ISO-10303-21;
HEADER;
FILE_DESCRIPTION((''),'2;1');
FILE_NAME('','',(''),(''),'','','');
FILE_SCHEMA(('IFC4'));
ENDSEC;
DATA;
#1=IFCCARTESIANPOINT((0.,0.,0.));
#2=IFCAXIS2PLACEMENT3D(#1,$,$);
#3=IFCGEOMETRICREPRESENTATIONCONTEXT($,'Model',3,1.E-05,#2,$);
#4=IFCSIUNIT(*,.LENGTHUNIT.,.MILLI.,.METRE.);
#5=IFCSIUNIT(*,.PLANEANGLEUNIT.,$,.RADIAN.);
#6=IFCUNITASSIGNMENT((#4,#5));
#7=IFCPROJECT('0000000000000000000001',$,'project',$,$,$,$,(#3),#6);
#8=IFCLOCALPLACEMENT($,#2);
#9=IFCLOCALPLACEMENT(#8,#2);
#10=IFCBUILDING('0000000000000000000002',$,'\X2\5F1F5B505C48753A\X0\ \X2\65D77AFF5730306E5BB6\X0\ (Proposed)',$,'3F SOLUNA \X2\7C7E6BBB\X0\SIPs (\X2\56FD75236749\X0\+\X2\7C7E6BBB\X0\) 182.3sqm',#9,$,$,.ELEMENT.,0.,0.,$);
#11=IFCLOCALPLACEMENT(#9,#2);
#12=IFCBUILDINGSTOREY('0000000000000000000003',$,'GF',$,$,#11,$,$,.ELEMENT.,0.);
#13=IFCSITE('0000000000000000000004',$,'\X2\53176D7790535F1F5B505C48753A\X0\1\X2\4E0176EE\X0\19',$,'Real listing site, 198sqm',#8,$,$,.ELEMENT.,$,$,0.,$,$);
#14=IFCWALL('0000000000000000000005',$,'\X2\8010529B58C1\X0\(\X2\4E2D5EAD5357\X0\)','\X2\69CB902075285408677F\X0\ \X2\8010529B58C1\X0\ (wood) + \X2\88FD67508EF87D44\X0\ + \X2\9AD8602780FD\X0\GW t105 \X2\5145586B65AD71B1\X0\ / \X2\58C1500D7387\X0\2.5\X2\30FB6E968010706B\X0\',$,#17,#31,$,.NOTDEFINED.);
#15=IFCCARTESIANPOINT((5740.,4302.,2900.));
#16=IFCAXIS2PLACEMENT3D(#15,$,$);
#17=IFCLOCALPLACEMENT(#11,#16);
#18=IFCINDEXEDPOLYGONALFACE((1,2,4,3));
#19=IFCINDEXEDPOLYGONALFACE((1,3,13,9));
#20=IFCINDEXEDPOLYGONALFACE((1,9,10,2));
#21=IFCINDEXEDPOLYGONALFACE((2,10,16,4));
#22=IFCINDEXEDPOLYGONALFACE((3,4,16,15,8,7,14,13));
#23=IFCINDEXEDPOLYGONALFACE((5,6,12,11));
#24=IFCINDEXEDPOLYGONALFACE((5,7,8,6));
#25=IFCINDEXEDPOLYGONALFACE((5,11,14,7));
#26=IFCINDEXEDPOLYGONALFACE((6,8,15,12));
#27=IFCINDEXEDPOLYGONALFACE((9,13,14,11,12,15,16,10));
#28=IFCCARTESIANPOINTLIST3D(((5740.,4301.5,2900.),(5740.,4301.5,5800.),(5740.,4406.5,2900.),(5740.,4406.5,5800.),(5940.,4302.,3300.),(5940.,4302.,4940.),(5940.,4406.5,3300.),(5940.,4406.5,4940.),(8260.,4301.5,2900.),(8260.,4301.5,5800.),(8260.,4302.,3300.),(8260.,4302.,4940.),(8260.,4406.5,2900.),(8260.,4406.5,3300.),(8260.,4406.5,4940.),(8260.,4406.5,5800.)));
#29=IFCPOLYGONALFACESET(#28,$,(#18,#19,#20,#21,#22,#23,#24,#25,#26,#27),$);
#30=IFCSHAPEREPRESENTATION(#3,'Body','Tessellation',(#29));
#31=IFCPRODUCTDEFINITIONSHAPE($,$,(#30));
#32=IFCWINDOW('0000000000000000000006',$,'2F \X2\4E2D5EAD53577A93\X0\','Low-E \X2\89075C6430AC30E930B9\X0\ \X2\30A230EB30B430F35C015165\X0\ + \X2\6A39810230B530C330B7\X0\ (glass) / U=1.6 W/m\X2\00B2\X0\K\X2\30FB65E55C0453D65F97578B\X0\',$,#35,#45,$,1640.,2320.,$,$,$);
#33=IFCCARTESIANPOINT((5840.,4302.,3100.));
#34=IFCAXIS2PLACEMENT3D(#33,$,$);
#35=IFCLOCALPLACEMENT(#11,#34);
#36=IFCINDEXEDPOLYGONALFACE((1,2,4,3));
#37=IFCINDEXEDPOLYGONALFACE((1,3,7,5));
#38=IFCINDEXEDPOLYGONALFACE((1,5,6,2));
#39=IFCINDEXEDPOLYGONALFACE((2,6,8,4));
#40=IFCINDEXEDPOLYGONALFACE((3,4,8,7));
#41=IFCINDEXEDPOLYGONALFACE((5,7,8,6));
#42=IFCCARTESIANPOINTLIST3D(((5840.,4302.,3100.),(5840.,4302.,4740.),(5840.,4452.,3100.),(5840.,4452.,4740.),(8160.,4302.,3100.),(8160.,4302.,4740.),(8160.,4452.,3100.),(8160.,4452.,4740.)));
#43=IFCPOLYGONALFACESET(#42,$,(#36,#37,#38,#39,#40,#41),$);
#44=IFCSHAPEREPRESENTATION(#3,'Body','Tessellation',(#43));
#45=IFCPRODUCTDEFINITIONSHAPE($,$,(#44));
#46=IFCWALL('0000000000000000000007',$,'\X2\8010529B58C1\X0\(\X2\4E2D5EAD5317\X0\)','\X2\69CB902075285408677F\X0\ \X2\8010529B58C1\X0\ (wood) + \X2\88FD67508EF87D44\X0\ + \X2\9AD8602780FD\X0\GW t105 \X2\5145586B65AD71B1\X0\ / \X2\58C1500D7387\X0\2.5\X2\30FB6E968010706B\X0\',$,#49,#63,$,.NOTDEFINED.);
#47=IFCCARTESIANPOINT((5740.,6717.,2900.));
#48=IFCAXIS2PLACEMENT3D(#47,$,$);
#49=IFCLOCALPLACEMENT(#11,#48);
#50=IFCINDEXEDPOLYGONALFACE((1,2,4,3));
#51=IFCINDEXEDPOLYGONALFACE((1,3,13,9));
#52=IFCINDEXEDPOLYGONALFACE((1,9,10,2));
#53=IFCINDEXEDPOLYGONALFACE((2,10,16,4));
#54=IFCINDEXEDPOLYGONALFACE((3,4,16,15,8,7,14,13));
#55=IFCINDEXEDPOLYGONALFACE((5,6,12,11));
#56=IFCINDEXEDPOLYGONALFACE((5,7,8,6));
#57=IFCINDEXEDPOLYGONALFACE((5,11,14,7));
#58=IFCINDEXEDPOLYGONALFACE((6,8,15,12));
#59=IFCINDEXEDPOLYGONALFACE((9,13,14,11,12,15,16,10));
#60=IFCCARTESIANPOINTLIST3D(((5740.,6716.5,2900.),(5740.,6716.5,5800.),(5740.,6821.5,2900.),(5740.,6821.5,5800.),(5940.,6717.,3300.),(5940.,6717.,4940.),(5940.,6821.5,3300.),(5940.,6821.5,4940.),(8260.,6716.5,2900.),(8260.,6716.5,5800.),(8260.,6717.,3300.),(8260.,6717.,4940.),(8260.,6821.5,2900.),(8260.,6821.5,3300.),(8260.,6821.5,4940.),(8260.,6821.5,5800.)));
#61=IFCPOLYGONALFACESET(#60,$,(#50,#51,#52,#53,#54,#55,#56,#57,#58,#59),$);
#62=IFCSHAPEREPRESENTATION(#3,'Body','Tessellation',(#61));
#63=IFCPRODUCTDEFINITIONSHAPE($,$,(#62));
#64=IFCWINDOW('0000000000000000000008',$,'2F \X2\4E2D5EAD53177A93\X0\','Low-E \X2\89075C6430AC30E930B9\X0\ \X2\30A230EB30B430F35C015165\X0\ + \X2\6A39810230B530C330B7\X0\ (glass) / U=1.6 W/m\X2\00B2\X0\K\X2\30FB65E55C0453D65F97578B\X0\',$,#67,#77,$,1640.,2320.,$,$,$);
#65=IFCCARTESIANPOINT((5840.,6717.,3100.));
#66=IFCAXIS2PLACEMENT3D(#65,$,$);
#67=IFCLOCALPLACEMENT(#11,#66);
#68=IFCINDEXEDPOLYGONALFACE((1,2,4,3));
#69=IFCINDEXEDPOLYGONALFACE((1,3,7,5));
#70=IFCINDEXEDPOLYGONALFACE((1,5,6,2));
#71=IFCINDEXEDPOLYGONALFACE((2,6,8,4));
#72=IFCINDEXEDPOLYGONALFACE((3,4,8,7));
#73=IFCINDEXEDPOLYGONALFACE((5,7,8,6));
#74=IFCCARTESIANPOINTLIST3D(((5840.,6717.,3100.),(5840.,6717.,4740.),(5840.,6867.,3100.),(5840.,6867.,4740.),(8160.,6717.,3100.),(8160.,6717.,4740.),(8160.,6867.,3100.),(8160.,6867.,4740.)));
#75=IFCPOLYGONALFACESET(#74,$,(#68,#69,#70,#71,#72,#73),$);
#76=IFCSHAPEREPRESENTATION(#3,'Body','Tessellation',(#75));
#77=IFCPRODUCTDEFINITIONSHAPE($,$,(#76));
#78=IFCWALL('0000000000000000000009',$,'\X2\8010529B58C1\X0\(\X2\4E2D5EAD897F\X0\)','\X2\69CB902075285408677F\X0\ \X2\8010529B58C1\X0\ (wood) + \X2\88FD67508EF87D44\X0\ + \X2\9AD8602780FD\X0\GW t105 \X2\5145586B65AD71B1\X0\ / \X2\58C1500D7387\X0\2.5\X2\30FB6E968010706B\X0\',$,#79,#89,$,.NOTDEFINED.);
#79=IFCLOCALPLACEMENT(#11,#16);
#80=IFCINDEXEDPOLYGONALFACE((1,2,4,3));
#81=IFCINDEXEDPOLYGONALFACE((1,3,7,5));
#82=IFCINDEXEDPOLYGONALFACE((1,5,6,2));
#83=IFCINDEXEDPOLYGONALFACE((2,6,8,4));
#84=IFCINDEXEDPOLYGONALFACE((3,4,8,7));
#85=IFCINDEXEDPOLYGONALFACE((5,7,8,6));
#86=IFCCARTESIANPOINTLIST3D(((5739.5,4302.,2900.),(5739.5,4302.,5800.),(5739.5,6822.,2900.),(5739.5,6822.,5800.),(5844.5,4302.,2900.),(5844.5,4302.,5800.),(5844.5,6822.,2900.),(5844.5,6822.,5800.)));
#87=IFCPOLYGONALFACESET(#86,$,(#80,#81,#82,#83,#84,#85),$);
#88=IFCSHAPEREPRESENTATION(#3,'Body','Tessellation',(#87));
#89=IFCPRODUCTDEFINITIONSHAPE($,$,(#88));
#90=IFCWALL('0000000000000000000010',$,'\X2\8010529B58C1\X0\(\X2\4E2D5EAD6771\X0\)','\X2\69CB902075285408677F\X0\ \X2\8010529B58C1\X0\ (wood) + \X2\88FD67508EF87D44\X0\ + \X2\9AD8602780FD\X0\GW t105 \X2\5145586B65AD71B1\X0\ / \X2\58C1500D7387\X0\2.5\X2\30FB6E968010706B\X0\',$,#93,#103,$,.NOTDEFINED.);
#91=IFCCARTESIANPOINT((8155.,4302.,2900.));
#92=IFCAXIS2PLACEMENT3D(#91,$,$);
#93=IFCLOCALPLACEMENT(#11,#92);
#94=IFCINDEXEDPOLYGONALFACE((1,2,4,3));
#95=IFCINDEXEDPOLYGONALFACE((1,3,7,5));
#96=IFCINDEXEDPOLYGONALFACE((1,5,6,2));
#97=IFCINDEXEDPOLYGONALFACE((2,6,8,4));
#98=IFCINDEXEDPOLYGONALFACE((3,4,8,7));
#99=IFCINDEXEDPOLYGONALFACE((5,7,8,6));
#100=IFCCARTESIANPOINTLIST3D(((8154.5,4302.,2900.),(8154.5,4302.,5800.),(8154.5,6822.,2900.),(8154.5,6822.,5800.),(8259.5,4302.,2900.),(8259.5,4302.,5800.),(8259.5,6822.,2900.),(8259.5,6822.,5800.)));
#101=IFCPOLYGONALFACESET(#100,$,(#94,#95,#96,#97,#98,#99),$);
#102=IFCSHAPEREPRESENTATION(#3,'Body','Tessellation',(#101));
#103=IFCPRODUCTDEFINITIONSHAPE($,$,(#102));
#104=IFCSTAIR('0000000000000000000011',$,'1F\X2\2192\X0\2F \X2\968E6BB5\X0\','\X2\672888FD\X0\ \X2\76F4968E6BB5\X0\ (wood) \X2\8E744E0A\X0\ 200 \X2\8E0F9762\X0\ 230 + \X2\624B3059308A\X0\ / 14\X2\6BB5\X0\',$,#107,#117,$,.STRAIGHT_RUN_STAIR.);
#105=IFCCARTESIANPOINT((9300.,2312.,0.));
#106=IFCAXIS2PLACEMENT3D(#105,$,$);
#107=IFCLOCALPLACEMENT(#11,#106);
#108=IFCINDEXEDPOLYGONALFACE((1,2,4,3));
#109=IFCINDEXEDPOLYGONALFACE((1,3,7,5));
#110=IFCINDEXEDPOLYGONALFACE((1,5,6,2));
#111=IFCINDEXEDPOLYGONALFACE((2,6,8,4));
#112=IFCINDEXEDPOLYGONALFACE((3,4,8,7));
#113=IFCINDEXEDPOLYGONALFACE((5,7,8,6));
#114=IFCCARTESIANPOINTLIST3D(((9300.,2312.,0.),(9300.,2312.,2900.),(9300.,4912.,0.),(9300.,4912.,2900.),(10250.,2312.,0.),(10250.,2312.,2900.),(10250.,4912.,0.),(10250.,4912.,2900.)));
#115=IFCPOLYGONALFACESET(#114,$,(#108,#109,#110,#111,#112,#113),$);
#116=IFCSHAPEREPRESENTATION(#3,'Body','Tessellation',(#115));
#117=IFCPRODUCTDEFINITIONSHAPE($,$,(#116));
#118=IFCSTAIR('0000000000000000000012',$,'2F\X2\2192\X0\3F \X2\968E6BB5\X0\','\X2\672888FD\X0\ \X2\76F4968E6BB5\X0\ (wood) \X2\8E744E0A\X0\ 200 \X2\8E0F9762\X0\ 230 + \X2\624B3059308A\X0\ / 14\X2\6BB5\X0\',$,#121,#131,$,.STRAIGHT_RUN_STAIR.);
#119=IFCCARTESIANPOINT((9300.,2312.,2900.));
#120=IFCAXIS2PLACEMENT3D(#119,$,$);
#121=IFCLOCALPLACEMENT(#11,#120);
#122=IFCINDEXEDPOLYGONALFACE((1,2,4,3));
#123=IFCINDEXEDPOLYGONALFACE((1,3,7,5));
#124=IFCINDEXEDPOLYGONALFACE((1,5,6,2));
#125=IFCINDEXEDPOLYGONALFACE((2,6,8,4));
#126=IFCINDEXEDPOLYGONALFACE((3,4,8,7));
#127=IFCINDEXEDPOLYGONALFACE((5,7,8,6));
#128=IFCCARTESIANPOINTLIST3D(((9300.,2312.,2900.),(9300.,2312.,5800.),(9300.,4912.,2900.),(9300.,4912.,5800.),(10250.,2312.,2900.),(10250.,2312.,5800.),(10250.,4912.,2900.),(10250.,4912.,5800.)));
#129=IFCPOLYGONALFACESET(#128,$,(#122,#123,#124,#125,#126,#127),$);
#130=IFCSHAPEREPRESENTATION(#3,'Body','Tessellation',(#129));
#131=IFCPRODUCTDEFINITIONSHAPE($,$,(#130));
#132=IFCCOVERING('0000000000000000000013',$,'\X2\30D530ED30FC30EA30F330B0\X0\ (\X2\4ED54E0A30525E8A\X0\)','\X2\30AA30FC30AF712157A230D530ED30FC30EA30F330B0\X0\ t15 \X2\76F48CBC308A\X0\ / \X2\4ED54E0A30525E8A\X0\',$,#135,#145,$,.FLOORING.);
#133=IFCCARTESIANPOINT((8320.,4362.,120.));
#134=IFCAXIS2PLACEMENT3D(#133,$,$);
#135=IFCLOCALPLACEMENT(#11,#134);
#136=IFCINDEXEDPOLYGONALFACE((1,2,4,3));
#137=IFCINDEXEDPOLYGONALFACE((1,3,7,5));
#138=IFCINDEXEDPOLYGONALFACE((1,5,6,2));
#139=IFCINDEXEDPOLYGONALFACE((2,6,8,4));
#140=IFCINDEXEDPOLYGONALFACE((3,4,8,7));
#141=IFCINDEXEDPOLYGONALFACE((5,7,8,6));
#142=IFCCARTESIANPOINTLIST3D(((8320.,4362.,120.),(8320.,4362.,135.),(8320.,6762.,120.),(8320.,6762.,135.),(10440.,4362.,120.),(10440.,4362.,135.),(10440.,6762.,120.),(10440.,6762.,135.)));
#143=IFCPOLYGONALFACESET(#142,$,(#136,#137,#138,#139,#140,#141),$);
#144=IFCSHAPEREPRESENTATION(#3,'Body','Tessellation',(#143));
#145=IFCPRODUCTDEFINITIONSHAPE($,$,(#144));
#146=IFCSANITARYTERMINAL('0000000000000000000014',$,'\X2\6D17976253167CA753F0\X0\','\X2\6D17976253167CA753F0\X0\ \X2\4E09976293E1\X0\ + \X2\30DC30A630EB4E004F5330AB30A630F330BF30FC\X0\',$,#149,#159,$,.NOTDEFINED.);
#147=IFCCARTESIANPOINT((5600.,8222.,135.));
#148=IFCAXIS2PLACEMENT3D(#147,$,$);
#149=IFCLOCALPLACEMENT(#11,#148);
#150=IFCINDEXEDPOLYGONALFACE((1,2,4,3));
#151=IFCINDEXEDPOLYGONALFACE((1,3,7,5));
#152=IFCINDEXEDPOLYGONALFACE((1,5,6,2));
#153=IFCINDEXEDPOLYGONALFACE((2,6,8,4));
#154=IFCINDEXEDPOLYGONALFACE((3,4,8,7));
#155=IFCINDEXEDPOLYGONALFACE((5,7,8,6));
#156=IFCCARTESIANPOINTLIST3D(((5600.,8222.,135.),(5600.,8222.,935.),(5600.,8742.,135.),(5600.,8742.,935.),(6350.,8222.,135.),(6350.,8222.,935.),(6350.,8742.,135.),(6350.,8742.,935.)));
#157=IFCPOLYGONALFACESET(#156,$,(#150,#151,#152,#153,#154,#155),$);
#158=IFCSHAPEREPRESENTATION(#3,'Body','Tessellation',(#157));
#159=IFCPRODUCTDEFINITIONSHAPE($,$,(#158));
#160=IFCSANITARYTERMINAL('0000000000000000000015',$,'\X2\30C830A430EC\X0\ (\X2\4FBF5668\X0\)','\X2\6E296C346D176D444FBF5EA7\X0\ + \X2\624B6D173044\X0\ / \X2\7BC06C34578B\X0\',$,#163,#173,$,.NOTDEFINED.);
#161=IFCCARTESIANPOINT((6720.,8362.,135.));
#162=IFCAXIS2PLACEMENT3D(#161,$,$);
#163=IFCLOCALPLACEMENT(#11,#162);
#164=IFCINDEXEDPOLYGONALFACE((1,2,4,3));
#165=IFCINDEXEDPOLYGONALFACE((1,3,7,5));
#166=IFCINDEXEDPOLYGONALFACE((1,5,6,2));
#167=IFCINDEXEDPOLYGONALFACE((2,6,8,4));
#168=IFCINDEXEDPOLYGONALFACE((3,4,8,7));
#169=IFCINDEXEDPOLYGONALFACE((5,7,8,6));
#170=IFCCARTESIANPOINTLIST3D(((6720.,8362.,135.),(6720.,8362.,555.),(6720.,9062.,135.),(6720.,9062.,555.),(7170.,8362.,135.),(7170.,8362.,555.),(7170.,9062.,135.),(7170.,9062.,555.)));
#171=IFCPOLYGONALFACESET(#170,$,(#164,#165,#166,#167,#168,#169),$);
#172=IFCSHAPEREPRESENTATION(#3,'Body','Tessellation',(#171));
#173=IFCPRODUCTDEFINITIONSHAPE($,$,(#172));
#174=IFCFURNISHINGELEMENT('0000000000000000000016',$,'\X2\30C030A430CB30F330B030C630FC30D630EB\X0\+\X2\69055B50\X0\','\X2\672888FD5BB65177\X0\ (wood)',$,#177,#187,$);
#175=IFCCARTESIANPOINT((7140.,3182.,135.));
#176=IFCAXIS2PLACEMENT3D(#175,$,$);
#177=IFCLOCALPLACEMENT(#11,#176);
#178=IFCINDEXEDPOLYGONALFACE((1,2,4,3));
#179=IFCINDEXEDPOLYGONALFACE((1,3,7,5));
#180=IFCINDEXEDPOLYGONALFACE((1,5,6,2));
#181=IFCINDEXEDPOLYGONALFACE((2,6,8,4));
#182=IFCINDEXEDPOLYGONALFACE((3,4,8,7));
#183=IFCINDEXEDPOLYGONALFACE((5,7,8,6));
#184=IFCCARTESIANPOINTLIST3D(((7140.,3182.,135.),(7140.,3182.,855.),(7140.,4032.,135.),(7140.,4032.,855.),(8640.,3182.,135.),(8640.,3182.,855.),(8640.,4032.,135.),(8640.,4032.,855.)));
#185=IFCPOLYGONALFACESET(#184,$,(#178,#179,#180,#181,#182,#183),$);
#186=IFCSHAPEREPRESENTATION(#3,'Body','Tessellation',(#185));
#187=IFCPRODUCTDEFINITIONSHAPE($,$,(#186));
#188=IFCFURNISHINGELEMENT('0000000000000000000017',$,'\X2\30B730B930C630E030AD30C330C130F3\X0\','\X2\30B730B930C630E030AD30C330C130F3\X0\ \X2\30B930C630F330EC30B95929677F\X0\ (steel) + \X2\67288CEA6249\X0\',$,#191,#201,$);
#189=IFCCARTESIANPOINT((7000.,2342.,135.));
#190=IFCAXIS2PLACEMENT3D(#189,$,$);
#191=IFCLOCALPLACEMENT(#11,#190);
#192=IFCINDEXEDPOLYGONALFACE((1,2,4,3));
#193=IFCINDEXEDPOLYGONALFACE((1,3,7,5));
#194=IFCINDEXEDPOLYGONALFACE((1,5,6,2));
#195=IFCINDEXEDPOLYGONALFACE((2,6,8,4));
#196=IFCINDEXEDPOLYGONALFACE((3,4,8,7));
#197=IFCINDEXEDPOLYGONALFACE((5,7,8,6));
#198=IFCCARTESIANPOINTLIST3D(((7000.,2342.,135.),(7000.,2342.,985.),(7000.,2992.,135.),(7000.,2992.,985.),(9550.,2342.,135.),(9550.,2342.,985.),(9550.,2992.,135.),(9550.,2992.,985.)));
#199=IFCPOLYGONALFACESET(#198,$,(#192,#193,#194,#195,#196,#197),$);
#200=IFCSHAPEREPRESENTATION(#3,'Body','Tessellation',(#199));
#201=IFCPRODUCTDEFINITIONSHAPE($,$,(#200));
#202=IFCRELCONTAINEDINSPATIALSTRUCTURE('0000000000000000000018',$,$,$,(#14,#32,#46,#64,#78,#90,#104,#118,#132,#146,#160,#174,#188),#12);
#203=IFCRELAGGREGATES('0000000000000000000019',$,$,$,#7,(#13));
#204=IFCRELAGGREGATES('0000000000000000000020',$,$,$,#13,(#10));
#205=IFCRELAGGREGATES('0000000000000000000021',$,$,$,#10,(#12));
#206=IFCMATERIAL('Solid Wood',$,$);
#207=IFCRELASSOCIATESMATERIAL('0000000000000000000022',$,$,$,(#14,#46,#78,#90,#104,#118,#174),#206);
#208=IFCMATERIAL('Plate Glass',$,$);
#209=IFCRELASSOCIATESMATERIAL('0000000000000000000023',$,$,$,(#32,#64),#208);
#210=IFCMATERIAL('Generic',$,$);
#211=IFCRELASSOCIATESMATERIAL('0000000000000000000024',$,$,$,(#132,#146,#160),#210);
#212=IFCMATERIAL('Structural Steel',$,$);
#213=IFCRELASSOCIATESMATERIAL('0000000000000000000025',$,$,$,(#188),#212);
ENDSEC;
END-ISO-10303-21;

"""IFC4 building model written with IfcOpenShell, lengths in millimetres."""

from ifc_helpers import new_model, si_unit, frame, frame_2d, origin, place, context, project, spatial, rectangle, extrude, material, element, fill, save


model = new_model("IFC4")

# Units and contexts
model_context = context("Model", 3, precision=1e-05, world=origin())
ifc_project = project(units=[si_unit("LENGTHUNIT", "METRE", prefix="MILLI"), si_unit("PLANEANGLEUNIT", "RADIAN")], contexts=[model_context])

# Site, building, storey
site_placement = place(None, origin())
site = spatial("IfcSite", under=ifc_project, at=site_placement, Name="北海道弟子屈町1丁目19", ObjectType="Real listing site, 198sqm", CompositionType="ELEMENT", RefElevation=0.0)
building_placement = place(site_placement, origin())
building = spatial("IfcBuilding", under=site, at=building_placement, Name="弟子屈町 旗竿地の家 (Proposed)", ObjectType="3F SOLUNA 籾殻SIPs (国産杉+籾殻) 182.3sqm", CompositionType="ELEMENT", ElevationOfRefHeight=0.0, ElevationOfTerrain=0.0)
storey_placement = place(building_placement, origin())
storey = spatial("IfcBuildingStorey", under=building, at=storey_placement, Name="GF", CompositionType="ELEMENT", Elevation=0.0)

# Shared definitions
ifc_material_1 = material(Name="Solid Wood")

# Shared definitions
ifc_material_2 = material(Name="Plate Glass")

# Walls, openings, windows
wall_1_placement = place(storey_placement, frame((5740.0, 4302.0, 2900.0)))
wall_1 = element("IfcWall", 1, at=wall_1_placement, inside=storey, material=ifc_material_1, Name="耐力壁(中庭南)", Description="構造用合板 耐力壁 (wood) + 製材軸組 + 高性能GW t105 充填断熱 / 壁倍率2.5・準耐火", PredefinedType="NOTDEFINED", context=model_context, shape_type="SweptSolid", body=[
    extrude(rectangle(XDim=2520.0, YDim=105.0, at=frame_2d((1260.0, 52.0))), frame((5740.0, 4302.0, 2900.0)), (0.0, 0.0, 1.0), 2900.0),
])
opening_1_placement = place(storey_placement, frame((5840.0, 4302.0, 3100.0)))
opening_1 = element("IfcOpeningElement", 2, at=opening_1_placement, cuts=wall_1, PredefinedType="NOTDEFINED", context=model_context, shape_type="SweptSolid", body=[
    extrude(rectangle(XDim=2320.0, YDim=150.0, at=frame_2d((1160.0, 75.0))), frame((5840.0, 4302.0, 3100.0)), (0.0, 0.0, 1.0), 1640.0),
])
window_1_placement = place(storey_placement, frame((5840.0, 4302.0, 3100.0)))
window_1 = element("IfcWindow", 3, at=window_1_placement, inside=storey, material=ifc_material_2, Name="2F 中庭南窓", Description="Low-E 複層ガラス アルゴン封入 + 樹脂サッシ (glass) / U=1.6 W/m²K・日射取得型", OverallHeight=1640.0, OverallWidth=2320.0, context=model_context, shape_type="SweptSolid", body=[
    extrude(rectangle(XDim=2320.0, YDim=150.0, at=frame_2d((1160.0, 75.0))), frame((5840.0, 4302.0, 3100.0)), (0.0, 0.0, 1.0), 1640.0),
])
fill(opening_1, window_1)
wall_2_placement = place(storey_placement, frame((5740.0, 6717.0, 2900.0)))
wall_2 = element("IfcWall", 4, at=wall_2_placement, inside=storey, material=ifc_material_1, Name="耐力壁(中庭北)", Description="構造用合板 耐力壁 (wood) + 製材軸組 + 高性能GW t105 充填断熱 / 壁倍率2.5・準耐火", PredefinedType="NOTDEFINED", context=model_context, shape_type="SweptSolid", body=[
    extrude(rectangle(XDim=2520.0, YDim=105.0, at=frame_2d((1260.0, 52.0))), frame((5740.0, 6717.0, 2900.0)), (0.0, 0.0, 1.0), 2900.0),
])
opening_2_placement = place(storey_placement, frame((5840.0, 6717.0, 3100.0)))
opening_2 = element("IfcOpeningElement", 5, at=opening_2_placement, cuts=wall_2, PredefinedType="NOTDEFINED", context=model_context, shape_type="SweptSolid", body=[
    extrude(rectangle(XDim=2320.0, YDim=150.0, at=frame_2d((1160.0, 75.0))), frame((5840.0, 6717.0, 3100.0)), (0.0, 0.0, 1.0), 1640.0),
])
window_2_placement = place(storey_placement, frame((5840.0, 6717.0, 3100.0)))
window_2 = element("IfcWindow", 6, at=window_2_placement, inside=storey, material=ifc_material_2, Name="2F 中庭北窓", Description="Low-E 複層ガラス アルゴン封入 + 樹脂サッシ (glass) / U=1.6 W/m²K・日射取得型", OverallHeight=1640.0, OverallWidth=2320.0, context=model_context, shape_type="SweptSolid", body=[
    extrude(rectangle(XDim=2320.0, YDim=150.0, at=frame_2d((1160.0, 75.0))), frame((5840.0, 6717.0, 3100.0)), (0.0, 0.0, 1.0), 1640.0),
])
fill(opening_2, window_2)

# Walls
wall_3_placement = place(storey_placement, frame((5740.0, 4302.0, 2900.0)))
element("IfcWall", 7, at=wall_3_placement, inside=storey, material=ifc_material_1, Name="耐力壁(中庭西)", Description="構造用合板 耐力壁 (wood) + 製材軸組 + 高性能GW t105 充填断熱 / 壁倍率2.5・準耐火", PredefinedType="NOTDEFINED", context=model_context, shape_type="SweptSolid", body=[
    extrude(rectangle(XDim=105.0, YDim=2520.0, at=frame_2d((52.0, 1260.0))), frame((5740.0, 4302.0, 2900.0)), (0.0, 0.0, 1.0), 2900.0),
])
wall_4_placement = place(storey_placement, frame((8155.0, 4302.0, 2900.0)))
element("IfcWall", 8, at=wall_4_placement, inside=storey, material=ifc_material_1, Name="耐力壁(中庭東)", Description="構造用合板 耐力壁 (wood) + 製材軸組 + 高性能GW t105 充填断熱 / 壁倍率2.5・準耐火", PredefinedType="NOTDEFINED", context=model_context, shape_type="SweptSolid", body=[
    extrude(rectangle(XDim=105.0, YDim=2520.0, at=frame_2d((52.0, 1260.0))), frame((8155.0, 4302.0, 2900.0)), (0.0, 0.0, 1.0), 2900.0),
])

# Stairs
stair_1_placement = place(storey_placement, frame((9300.0, 2312.0, 0.0)))
element("IfcStair", 9, at=stair_1_placement, inside=storey, material=ifc_material_1, Name="1F→2F 階段", Description="木製 直階段 (wood) 蹴上 200 踏面 230 + 手すり / 14段", PredefinedType="STRAIGHT_RUN_STAIR", context=model_context, shape_type="SweptSolid", body=[
    extrude(rectangle(XDim=950.0, YDim=2600.0, at=frame_2d((475.0, 1300.0))), frame((9300.0, 2312.0, 0.0)), (0.0, 0.0, 1.0), 2900.0),
])
stair_2_placement = place(storey_placement, frame((9300.0, 2312.0, 2900.0)))
element("IfcStair", 10, at=stair_2_placement, inside=storey, material=ifc_material_1, Name="2F→3F 階段", Description="木製 直階段 (wood) 蹴上 200 踏面 230 + 手すり / 14段", PredefinedType="STRAIGHT_RUN_STAIR", context=model_context, shape_type="SweptSolid", body=[
    extrude(rectangle(XDim=950.0, YDim=2600.0, at=frame_2d((475.0, 1300.0))), frame((9300.0, 2312.0, 2900.0)), (0.0, 0.0, 1.0), 2900.0),
])

# Covering
ifc_material_3 = material(Name="Generic")
covering_placement = place(storey_placement, frame((8320.0, 4362.0, 120.0)))
element("IfcCovering", 11, at=covering_placement, inside=storey, material=ifc_material_3, Name="フローリング (仕上げ床)", Description="オーク無垢フローリング t15 直貼り / 仕上げ床", PredefinedType="FLOORING", context=model_context, shape_type="SweptSolid", body=[
    extrude(rectangle(XDim=2120.0, YDim=2400.0, at=frame_2d((1060.0, 1200.0))), frame((8320.0, 4362.0, 120.0)), (0.0, 0.0, 1.0), 15.0),
])

# Sanitary terminals
sanitary_terminal_1_placement = place(storey_placement, frame((5600.0, 8222.0, 135.0)))
element("IfcSanitaryTerminal", 12, at=sanitary_terminal_1_placement, inside=storey, material=ifc_material_3, Name="洗面化粧台", Description="洗面化粧台 三面鏡 + ボウル一体カウンター", PredefinedType="NOTDEFINED", context=model_context, shape_type="SweptSolid", body=[
    extrude(rectangle(XDim=750.0, YDim=520.0, at=frame_2d((375.0, 260.0))), frame((5600.0, 8222.0, 135.0)), (0.0, 0.0, 1.0), 800.0),
])
sanitary_terminal_2_placement = place(storey_placement, frame((6720.0, 8362.0, 135.0)))
element("IfcSanitaryTerminal", 13, at=sanitary_terminal_2_placement, inside=storey, material=ifc_material_3, Name="トイレ (便器)", Description="温水洗浄便座 + 手洗い / 節水型", PredefinedType="NOTDEFINED", context=model_context, shape_type="SweptSolid", body=[
    extrude(rectangle(XDim=450.0, YDim=700.0, at=frame_2d((225.0, 350.0))), frame((6720.0, 8362.0, 135.0)), (0.0, 0.0, 1.0), 420.0),
])

# Furnishing elements
furnishing_1_placement = place(storey_placement, frame((7140.0, 3182.0, 135.0)))
element("IfcFurnishingElement", 14, at=furnishing_1_placement, inside=storey, material=ifc_material_1, Name="ダイニングテーブル+椅子", Description="木製家具 (wood)", context=model_context, shape_type="SweptSolid", body=[
    extrude(rectangle(XDim=1500.0, YDim=850.0, at=frame_2d((750.0, 425.0))), frame((7140.0, 3182.0, 135.0)), (0.0, 0.0, 1.0), 720.0),
])
ifc_material_4 = material(Name="Structural Steel")
furnishing_2_placement = place(storey_placement, frame((7000.0, 2342.0, 135.0)))
element("IfcFurnishingElement", 15, at=furnishing_2_placement, inside=storey, material=ifc_material_4, Name="システムキッチン", Description="システムキッチン ステンレス天板 (steel) + 木質扉", context=model_context, shape_type="SweptSolid", body=[
    extrude(rectangle(XDim=2550.0, YDim=650.0, at=frame_2d((1275.0, 325.0))), frame((7000.0, 2342.0, 135.0)), (0.0, 0.0, 1.0), 850.0),
])

save(model, "model.ifc")
